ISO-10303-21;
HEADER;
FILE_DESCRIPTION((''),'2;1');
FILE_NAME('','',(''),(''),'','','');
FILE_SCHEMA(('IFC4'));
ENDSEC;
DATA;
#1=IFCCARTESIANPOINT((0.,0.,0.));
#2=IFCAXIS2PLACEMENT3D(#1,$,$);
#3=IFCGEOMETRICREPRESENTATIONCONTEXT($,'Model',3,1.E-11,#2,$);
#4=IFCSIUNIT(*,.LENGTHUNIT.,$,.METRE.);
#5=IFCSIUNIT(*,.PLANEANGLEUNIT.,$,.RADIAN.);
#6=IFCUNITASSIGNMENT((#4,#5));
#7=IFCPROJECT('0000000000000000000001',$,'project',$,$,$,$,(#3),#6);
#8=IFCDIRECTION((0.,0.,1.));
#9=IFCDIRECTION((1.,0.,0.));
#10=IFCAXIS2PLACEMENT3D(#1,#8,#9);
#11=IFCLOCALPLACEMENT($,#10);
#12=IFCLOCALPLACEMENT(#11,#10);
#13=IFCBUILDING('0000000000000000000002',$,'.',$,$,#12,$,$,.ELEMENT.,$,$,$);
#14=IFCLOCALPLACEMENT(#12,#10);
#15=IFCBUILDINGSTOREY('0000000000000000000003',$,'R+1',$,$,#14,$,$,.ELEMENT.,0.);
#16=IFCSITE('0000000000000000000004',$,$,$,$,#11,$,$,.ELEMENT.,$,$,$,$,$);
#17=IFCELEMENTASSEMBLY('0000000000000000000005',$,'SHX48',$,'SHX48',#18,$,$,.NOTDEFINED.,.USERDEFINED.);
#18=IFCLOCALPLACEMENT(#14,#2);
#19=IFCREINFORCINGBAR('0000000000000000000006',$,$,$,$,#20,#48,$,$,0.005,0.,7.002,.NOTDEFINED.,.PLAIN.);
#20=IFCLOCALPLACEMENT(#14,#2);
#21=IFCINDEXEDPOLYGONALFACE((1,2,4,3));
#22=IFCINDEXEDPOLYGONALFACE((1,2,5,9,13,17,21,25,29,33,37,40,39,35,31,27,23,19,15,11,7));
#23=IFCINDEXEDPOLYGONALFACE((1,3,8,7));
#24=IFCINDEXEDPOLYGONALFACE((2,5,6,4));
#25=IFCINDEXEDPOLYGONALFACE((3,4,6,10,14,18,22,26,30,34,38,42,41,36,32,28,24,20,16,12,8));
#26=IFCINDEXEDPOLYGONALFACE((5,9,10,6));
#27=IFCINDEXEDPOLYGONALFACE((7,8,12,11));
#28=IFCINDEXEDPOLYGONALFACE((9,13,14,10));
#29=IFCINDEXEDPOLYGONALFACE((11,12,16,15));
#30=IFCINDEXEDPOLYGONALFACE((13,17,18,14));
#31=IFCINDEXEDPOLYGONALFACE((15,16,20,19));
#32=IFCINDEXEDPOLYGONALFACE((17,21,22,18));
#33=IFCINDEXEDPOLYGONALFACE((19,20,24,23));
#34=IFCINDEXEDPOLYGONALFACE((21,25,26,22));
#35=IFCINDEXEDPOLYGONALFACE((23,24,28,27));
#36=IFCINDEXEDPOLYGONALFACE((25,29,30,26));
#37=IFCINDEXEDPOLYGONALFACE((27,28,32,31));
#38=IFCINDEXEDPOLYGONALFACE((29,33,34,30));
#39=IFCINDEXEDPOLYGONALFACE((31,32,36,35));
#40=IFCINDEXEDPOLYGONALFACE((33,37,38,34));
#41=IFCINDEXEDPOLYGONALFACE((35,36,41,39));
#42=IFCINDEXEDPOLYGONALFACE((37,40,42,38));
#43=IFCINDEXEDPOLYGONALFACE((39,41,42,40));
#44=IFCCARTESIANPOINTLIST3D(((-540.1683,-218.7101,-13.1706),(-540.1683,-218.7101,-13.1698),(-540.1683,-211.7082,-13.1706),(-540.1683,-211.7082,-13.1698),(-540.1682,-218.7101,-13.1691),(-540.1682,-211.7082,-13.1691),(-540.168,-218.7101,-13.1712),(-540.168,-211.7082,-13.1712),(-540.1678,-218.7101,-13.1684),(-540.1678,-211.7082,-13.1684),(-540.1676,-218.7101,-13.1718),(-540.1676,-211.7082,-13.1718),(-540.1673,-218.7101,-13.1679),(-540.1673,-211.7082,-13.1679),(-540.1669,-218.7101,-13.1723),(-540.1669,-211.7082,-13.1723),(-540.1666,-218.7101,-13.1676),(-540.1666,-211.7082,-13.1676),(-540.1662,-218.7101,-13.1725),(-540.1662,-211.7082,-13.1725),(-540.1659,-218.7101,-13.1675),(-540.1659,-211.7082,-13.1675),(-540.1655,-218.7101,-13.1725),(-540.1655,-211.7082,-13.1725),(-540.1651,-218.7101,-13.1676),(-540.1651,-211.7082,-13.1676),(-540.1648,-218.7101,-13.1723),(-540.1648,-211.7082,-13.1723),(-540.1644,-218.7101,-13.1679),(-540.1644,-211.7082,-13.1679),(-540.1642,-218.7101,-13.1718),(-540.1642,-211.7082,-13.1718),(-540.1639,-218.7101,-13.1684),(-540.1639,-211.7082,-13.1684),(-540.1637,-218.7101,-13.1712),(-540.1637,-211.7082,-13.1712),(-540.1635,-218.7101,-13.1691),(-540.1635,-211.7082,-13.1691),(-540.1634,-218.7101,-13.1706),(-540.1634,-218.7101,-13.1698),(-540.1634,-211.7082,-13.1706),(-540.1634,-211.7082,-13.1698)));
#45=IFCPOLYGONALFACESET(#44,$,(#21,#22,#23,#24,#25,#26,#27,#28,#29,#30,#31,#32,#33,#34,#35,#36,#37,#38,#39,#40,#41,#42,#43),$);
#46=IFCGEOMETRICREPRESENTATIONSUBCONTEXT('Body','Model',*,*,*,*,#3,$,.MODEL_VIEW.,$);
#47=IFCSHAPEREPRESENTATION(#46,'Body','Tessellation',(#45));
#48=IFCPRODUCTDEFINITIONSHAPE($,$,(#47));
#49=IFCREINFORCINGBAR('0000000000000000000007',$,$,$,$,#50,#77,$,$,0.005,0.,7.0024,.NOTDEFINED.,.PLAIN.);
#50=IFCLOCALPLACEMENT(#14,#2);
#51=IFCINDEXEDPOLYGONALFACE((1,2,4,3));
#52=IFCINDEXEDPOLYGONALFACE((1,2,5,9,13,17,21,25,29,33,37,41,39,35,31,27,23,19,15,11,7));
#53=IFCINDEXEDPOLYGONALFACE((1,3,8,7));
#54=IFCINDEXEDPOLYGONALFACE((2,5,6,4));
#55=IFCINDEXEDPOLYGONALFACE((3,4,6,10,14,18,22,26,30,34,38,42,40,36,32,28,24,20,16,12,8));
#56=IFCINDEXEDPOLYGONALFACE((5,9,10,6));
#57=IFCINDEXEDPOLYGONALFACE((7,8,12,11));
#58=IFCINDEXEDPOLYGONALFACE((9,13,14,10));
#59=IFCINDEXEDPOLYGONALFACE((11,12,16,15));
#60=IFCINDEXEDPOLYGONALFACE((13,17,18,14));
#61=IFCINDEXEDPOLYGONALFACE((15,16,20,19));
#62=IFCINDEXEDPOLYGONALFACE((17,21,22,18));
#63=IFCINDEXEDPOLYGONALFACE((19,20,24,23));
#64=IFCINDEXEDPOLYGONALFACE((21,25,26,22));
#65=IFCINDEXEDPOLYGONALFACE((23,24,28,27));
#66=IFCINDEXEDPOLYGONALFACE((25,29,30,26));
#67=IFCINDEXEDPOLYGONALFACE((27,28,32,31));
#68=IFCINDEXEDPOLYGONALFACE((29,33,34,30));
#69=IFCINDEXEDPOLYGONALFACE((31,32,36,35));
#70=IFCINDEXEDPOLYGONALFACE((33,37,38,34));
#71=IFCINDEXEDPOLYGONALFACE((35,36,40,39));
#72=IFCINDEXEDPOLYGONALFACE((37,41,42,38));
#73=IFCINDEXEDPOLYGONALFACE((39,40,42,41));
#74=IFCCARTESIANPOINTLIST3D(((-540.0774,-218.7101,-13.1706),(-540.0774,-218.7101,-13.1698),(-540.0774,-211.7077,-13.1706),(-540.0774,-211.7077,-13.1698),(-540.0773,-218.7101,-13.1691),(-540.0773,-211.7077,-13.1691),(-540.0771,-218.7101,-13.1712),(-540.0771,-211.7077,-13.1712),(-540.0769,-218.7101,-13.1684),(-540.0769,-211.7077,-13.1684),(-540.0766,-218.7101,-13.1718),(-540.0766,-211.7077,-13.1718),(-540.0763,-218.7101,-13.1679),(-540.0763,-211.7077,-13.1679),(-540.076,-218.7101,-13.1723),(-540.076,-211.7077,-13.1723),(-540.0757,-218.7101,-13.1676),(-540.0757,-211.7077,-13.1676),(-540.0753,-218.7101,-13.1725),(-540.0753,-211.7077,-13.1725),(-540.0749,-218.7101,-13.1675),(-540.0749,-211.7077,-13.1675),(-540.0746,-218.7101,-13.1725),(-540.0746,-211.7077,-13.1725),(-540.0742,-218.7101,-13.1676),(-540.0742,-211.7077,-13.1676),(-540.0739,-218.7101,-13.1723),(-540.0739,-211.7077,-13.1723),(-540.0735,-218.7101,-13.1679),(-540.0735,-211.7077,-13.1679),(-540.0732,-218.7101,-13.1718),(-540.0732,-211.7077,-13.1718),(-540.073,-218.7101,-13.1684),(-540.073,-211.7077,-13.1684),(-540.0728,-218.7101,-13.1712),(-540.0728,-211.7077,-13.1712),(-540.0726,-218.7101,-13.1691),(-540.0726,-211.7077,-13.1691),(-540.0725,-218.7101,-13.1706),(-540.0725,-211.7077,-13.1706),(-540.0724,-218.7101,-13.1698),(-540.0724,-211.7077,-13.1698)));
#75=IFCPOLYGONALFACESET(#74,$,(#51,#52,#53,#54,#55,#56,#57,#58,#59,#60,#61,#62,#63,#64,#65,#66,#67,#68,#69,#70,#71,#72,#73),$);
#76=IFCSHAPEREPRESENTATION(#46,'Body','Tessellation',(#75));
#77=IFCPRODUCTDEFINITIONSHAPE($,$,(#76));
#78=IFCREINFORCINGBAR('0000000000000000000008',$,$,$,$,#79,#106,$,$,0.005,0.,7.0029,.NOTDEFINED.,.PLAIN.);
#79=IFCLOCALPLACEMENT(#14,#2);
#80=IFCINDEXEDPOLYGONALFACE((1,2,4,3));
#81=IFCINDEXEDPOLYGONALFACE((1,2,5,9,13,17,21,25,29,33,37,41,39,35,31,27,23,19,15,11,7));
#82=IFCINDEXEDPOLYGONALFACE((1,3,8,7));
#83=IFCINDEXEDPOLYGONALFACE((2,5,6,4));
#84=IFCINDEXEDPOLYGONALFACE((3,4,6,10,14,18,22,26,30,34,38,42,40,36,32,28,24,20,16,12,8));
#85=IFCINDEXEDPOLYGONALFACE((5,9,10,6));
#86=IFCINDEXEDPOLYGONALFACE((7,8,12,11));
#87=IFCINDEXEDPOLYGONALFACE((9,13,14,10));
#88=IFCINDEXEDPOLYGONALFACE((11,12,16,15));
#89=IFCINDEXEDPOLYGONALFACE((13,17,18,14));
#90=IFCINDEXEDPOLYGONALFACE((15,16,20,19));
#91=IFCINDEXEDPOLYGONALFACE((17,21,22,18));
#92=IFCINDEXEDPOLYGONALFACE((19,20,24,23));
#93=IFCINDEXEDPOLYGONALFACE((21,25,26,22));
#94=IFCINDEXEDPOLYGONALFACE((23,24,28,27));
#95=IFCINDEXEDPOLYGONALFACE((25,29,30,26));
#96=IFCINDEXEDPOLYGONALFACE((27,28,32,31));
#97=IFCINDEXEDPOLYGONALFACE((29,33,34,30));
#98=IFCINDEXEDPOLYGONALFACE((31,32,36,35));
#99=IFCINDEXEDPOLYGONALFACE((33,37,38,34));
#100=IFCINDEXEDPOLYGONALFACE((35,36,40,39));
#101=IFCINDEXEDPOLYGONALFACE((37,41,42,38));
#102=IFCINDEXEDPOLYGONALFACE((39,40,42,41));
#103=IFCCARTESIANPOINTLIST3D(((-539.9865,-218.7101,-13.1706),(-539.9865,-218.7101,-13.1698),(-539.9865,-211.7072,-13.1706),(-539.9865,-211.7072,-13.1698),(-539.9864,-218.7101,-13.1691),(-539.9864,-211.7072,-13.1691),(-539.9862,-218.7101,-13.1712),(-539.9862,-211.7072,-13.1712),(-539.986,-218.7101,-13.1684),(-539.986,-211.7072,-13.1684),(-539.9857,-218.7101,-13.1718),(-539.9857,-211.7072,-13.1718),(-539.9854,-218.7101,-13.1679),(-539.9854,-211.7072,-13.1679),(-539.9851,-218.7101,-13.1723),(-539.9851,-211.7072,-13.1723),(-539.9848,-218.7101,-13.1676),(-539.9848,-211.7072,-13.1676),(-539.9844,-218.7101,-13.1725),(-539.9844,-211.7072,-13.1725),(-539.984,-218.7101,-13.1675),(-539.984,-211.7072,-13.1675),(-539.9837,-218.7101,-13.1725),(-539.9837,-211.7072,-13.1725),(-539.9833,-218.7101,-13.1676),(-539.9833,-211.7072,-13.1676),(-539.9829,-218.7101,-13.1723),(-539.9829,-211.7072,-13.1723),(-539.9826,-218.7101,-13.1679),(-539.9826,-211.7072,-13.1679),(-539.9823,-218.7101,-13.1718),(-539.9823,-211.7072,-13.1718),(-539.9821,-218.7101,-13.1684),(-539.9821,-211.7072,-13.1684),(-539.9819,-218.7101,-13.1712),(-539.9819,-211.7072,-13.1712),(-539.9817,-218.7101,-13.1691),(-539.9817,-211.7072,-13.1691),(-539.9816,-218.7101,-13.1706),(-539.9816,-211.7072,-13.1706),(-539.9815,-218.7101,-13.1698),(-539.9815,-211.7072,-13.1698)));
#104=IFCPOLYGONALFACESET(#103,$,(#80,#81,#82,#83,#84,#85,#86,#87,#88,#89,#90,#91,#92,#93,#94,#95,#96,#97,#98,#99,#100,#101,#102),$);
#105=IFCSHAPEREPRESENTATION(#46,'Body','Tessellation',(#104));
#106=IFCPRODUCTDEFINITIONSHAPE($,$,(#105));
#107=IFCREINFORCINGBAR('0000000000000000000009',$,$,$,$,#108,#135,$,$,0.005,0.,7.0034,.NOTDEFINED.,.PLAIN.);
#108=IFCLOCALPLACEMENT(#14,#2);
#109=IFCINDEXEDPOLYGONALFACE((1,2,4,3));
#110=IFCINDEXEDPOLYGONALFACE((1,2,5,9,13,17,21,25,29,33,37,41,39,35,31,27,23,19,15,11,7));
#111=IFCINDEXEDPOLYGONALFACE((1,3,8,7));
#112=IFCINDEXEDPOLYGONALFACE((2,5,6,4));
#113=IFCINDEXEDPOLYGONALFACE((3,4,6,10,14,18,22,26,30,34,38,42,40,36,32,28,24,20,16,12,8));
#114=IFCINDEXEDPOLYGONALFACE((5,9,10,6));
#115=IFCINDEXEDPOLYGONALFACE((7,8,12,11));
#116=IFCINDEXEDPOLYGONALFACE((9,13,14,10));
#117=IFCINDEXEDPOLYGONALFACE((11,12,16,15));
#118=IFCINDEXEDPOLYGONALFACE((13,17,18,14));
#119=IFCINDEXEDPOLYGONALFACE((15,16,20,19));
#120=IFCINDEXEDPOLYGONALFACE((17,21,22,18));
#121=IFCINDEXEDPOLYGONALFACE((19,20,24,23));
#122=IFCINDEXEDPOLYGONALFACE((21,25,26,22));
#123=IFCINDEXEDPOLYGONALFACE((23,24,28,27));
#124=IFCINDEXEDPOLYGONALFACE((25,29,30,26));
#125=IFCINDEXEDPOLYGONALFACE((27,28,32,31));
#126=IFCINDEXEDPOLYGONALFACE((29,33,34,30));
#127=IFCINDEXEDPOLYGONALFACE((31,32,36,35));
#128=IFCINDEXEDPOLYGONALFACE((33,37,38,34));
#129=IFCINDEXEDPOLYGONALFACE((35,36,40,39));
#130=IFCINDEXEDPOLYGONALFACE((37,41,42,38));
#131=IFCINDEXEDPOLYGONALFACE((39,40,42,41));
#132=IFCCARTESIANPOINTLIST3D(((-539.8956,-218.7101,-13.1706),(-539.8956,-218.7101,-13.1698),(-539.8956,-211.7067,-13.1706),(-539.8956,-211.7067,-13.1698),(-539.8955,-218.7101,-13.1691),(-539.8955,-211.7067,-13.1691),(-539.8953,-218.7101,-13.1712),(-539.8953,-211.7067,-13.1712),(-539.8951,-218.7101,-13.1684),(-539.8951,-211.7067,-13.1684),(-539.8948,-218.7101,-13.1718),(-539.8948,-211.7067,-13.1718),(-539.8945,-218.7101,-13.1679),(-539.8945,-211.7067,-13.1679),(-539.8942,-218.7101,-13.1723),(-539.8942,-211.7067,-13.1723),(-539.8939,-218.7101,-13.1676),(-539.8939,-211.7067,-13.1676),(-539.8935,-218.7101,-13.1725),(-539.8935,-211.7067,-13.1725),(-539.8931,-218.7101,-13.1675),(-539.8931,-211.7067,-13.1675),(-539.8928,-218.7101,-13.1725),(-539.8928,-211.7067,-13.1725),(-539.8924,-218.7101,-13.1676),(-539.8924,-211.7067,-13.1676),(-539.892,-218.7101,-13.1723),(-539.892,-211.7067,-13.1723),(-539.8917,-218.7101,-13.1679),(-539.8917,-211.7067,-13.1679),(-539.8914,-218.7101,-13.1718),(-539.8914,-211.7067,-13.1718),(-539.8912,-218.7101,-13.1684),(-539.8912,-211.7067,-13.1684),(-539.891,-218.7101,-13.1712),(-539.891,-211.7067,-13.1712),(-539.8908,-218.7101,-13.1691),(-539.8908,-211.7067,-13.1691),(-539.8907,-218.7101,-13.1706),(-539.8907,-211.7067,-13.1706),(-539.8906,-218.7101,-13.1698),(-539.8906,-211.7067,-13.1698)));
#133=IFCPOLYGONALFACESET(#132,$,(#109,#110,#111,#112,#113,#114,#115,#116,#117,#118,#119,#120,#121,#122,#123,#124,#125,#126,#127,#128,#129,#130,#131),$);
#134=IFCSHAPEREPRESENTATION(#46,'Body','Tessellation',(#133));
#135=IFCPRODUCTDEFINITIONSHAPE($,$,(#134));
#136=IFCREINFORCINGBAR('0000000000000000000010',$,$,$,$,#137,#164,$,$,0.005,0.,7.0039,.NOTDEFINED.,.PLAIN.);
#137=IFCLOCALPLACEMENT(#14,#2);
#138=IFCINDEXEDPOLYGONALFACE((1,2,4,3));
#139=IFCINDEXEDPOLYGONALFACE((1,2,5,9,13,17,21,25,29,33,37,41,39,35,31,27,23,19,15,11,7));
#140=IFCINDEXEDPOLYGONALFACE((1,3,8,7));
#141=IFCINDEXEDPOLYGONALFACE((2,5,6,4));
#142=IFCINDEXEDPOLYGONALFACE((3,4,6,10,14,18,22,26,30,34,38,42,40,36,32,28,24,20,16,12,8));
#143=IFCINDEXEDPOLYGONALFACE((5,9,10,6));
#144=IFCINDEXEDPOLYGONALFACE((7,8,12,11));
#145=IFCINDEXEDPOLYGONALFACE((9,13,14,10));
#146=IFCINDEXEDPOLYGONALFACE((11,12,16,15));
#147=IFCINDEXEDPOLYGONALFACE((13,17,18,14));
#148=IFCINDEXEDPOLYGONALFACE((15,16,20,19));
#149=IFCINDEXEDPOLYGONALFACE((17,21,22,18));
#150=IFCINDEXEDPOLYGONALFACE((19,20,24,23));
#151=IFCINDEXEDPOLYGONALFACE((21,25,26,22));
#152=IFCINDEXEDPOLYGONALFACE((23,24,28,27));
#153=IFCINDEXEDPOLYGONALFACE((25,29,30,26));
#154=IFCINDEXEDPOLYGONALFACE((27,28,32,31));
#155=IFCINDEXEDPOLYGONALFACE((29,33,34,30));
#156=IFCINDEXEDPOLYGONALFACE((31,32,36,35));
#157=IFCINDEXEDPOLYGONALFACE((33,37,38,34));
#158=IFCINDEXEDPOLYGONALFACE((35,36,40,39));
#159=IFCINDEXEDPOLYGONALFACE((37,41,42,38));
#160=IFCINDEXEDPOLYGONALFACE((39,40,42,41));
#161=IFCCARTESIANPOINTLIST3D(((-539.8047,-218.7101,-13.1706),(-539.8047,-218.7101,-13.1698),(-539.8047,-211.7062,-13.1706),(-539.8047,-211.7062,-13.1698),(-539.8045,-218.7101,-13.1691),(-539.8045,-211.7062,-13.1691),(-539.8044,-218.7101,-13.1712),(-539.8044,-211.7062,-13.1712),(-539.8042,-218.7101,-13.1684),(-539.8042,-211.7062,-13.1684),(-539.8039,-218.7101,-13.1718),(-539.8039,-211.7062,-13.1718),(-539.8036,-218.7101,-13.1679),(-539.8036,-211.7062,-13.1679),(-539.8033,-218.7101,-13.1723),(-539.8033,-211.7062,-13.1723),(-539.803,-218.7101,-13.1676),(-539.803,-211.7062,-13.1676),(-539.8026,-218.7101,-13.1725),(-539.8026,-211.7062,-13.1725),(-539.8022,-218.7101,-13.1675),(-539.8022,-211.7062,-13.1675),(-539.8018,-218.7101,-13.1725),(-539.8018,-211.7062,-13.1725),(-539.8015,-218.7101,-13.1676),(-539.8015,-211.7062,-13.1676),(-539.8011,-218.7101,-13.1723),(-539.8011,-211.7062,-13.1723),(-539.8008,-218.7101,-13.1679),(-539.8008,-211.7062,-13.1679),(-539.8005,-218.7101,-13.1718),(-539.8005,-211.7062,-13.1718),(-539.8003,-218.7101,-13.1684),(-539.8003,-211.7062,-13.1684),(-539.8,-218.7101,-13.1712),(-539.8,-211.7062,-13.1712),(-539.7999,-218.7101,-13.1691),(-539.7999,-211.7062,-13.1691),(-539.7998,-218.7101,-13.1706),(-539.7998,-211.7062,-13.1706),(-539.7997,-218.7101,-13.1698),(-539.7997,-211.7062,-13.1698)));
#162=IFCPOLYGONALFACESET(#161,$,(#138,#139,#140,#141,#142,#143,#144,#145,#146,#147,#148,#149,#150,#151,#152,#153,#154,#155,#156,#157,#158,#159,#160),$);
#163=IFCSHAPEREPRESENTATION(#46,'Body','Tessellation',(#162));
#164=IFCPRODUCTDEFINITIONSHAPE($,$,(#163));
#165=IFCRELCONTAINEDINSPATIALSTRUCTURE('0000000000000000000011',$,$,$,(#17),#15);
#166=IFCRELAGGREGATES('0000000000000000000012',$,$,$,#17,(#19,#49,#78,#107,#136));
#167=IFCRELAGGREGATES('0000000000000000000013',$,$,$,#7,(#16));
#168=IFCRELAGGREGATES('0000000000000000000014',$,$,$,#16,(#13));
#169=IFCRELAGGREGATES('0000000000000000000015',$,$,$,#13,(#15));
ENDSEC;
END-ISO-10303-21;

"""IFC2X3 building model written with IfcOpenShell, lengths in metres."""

from ifc_helpers import new_model, entity, si_unit, origin, origin_with_axes, place, context, subcontext, project, spatial, shape, element, aggregate, save


model = new_model("IFC2X3")

# Units and contexts
model_context = context("Model", 3, precision=1e-11, world=origin())
body_context = subcontext(model_context, "Body", "Model", "MODEL_VIEW")
ifc_project = project(units=[si_unit("LENGTHUNIT", "METRE"), si_unit("PLANEANGLEUNIT", "RADIAN")], contexts=[model_context])

# Site, building, storey
site_placement = place(None, origin_with_axes())
site = spatial("IfcSite", under=ifc_project, at=site_placement, CompositionType="ELEMENT")
building_placement = place(site_placement, origin_with_axes())
building = spatial("IfcBuilding", under=site, at=building_placement, Name=".", CompositionType="ELEMENT")
storey_placement = place(building_placement, origin_with_axes())
storey = spatial("IfcBuildingStorey", under=building, at=storey_placement, Name="R+1", CompositionType="ELEMENT", Elevation=0.0)

# Element assembly, reinforcing bars
assembly_1_placement = place(storey_placement, origin_with_axes())
assembly_1 = element("IfcElementAssembly", 1, at=assembly_1_placement, inside=storey, Name="SHX48", ObjectType="SHX48", AssemblyPlace="NOTDEFINED", PredefinedType="USERDEFINED")
reinforcing_bar_1_placement = place(assembly_1_placement, origin_with_axes())
reinforcing_bar_1 = element("IfcReinforcingBar", 2, at=reinforcing_bar_1_placement, BarLength=7.002, BarRole="NOTDEFINED", BarSurface="PLAIN", CrossSectionArea=0.0, NominalDiameter=0.005, shapes=[
    shape(body_context, "Body", "AdvancedSweptSolid", [entity("IfcSweptDiskSolid", entity("IfcPolyline", [entity("IfcCartesianPoint", [540.1659, 211.7082, 13.17]), entity("IfcCartesianPoint", [540.1659, 218.7101, 13.17])]), 0.0025, None, 0.0, 7.002)]),
    shape(body_context, "Body", "AdvancedSweptSolid", [entity("IfcSweptDiskSolid", entity("IfcPolyline", [entity("IfcCartesianPoint", [540.1659, 211.7082, 13.17]), entity("IfcCartesianPoint", [540.1659, 218.7101, 13.17])]), 0.0025, None, 0.0, 7.002)]),
])
reinforcing_bar_2_placement = place(assembly_1_placement, origin_with_axes())
reinforcing_bar_2 = element("IfcReinforcingBar", 3, at=reinforcing_bar_2_placement, BarLength=7.0024, BarRole="NOTDEFINED", BarSurface="PLAIN", CrossSectionArea=0.0, NominalDiameter=0.005, shapes=[
    shape(body_context, "Body", "AdvancedSweptSolid", [entity("IfcSweptDiskSolid", entity("IfcPolyline", [entity("IfcCartesianPoint", [540.0749, 211.7077, 13.17]), entity("IfcCartesianPoint", [540.0749, 218.7101, 13.17])]), 0.0025, None, 0.0, 7.0024)]),
    shape(body_context, "Body", "AdvancedSweptSolid", [entity("IfcSweptDiskSolid", entity("IfcPolyline", [entity("IfcCartesianPoint", [540.0749, 211.7077, 13.17]), entity("IfcCartesianPoint", [540.0749, 218.7101, 13.17])]), 0.0025, None, 0.0, 7.0024)]),
])
reinforcing_bar_3_placement = place(assembly_1_placement, origin_with_axes())
reinforcing_bar_3 = element("IfcReinforcingBar", 4, at=reinforcing_bar_3_placement, BarLength=7.0029, BarRole="NOTDEFINED", BarSurface="PLAIN", CrossSectionArea=0.0, NominalDiameter=0.005, shapes=[
    shape(body_context, "Body", "AdvancedSweptSolid", [entity("IfcSweptDiskSolid", entity("IfcPolyline", [entity("IfcCartesianPoint", [539.984, 211.7072, 13.17]), entity("IfcCartesianPoint", [539.984, 218.7101, 13.17])]), 0.0025, None, 0.0, 7.0029)]),
    shape(body_context, "Body", "AdvancedSweptSolid", [entity("IfcSweptDiskSolid", entity("IfcPolyline", [entity("IfcCartesianPoint", [539.984, 211.7072, 13.17]), entity("IfcCartesianPoint", [539.984, 218.7101, 13.17])]), 0.0025, None, 0.0, 7.0029)]),
])
reinforcing_bar_4_placement = place(assembly_1_placement, origin_with_axes())
reinforcing_bar_4 = element("IfcReinforcingBar", 5, at=reinforcing_bar_4_placement, BarLength=7.0034, BarRole="NOTDEFINED", BarSurface="PLAIN", CrossSectionArea=0.0, NominalDiameter=0.005, shapes=[
    shape(body_context, "Body", "AdvancedSweptSolid", [entity("IfcSweptDiskSolid", entity("IfcPolyline", [entity("IfcCartesianPoint", [539.8931, 211.7067, 13.17]), entity("IfcCartesianPoint", [539.8931, 218.7101, 13.17])]), 0.0025, None, 0.0, 7.0034)]),
    shape(body_context, "Body", "AdvancedSweptSolid", [entity("IfcSweptDiskSolid", entity("IfcPolyline", [entity("IfcCartesianPoint", [539.8931, 211.7067, 13.17]), entity("IfcCartesianPoint", [539.8931, 218.7101, 13.17])]), 0.0025, None, 0.0, 7.0034)]),
])
reinforcing_bar_5_placement = place(assembly_1_placement, origin_with_axes())
reinforcing_bar_5 = element("IfcReinforcingBar", 6, at=reinforcing_bar_5_placement, BarLength=7.0039, BarRole="NOTDEFINED", BarSurface="PLAIN", CrossSectionArea=0.0, NominalDiameter=0.005, shapes=[
    shape(body_context, "Body", "AdvancedSweptSolid", [entity("IfcSweptDiskSolid", entity("IfcPolyline", [entity("IfcCartesianPoint", [539.8022, 211.7062, 13.17]), entity("IfcCartesianPoint", [539.8022, 218.7101, 13.17])]), 0.0025, None, 0.0, 7.0039)]),
    shape(body_context, "Body", "AdvancedSweptSolid", [entity("IfcSweptDiskSolid", entity("IfcPolyline", [entity("IfcCartesianPoint", [539.8022, 211.7062, 13.17]), entity("IfcCartesianPoint", [539.8022, 218.7101, 13.17])]), 0.0025, None, 0.0, 7.0039)]),
])
aggregate(assembly_1, [reinforcing_bar_1, reinforcing_bar_2, reinforcing_bar_3, reinforcing_bar_4, reinforcing_bar_5])

save(model, "model.ifc")
